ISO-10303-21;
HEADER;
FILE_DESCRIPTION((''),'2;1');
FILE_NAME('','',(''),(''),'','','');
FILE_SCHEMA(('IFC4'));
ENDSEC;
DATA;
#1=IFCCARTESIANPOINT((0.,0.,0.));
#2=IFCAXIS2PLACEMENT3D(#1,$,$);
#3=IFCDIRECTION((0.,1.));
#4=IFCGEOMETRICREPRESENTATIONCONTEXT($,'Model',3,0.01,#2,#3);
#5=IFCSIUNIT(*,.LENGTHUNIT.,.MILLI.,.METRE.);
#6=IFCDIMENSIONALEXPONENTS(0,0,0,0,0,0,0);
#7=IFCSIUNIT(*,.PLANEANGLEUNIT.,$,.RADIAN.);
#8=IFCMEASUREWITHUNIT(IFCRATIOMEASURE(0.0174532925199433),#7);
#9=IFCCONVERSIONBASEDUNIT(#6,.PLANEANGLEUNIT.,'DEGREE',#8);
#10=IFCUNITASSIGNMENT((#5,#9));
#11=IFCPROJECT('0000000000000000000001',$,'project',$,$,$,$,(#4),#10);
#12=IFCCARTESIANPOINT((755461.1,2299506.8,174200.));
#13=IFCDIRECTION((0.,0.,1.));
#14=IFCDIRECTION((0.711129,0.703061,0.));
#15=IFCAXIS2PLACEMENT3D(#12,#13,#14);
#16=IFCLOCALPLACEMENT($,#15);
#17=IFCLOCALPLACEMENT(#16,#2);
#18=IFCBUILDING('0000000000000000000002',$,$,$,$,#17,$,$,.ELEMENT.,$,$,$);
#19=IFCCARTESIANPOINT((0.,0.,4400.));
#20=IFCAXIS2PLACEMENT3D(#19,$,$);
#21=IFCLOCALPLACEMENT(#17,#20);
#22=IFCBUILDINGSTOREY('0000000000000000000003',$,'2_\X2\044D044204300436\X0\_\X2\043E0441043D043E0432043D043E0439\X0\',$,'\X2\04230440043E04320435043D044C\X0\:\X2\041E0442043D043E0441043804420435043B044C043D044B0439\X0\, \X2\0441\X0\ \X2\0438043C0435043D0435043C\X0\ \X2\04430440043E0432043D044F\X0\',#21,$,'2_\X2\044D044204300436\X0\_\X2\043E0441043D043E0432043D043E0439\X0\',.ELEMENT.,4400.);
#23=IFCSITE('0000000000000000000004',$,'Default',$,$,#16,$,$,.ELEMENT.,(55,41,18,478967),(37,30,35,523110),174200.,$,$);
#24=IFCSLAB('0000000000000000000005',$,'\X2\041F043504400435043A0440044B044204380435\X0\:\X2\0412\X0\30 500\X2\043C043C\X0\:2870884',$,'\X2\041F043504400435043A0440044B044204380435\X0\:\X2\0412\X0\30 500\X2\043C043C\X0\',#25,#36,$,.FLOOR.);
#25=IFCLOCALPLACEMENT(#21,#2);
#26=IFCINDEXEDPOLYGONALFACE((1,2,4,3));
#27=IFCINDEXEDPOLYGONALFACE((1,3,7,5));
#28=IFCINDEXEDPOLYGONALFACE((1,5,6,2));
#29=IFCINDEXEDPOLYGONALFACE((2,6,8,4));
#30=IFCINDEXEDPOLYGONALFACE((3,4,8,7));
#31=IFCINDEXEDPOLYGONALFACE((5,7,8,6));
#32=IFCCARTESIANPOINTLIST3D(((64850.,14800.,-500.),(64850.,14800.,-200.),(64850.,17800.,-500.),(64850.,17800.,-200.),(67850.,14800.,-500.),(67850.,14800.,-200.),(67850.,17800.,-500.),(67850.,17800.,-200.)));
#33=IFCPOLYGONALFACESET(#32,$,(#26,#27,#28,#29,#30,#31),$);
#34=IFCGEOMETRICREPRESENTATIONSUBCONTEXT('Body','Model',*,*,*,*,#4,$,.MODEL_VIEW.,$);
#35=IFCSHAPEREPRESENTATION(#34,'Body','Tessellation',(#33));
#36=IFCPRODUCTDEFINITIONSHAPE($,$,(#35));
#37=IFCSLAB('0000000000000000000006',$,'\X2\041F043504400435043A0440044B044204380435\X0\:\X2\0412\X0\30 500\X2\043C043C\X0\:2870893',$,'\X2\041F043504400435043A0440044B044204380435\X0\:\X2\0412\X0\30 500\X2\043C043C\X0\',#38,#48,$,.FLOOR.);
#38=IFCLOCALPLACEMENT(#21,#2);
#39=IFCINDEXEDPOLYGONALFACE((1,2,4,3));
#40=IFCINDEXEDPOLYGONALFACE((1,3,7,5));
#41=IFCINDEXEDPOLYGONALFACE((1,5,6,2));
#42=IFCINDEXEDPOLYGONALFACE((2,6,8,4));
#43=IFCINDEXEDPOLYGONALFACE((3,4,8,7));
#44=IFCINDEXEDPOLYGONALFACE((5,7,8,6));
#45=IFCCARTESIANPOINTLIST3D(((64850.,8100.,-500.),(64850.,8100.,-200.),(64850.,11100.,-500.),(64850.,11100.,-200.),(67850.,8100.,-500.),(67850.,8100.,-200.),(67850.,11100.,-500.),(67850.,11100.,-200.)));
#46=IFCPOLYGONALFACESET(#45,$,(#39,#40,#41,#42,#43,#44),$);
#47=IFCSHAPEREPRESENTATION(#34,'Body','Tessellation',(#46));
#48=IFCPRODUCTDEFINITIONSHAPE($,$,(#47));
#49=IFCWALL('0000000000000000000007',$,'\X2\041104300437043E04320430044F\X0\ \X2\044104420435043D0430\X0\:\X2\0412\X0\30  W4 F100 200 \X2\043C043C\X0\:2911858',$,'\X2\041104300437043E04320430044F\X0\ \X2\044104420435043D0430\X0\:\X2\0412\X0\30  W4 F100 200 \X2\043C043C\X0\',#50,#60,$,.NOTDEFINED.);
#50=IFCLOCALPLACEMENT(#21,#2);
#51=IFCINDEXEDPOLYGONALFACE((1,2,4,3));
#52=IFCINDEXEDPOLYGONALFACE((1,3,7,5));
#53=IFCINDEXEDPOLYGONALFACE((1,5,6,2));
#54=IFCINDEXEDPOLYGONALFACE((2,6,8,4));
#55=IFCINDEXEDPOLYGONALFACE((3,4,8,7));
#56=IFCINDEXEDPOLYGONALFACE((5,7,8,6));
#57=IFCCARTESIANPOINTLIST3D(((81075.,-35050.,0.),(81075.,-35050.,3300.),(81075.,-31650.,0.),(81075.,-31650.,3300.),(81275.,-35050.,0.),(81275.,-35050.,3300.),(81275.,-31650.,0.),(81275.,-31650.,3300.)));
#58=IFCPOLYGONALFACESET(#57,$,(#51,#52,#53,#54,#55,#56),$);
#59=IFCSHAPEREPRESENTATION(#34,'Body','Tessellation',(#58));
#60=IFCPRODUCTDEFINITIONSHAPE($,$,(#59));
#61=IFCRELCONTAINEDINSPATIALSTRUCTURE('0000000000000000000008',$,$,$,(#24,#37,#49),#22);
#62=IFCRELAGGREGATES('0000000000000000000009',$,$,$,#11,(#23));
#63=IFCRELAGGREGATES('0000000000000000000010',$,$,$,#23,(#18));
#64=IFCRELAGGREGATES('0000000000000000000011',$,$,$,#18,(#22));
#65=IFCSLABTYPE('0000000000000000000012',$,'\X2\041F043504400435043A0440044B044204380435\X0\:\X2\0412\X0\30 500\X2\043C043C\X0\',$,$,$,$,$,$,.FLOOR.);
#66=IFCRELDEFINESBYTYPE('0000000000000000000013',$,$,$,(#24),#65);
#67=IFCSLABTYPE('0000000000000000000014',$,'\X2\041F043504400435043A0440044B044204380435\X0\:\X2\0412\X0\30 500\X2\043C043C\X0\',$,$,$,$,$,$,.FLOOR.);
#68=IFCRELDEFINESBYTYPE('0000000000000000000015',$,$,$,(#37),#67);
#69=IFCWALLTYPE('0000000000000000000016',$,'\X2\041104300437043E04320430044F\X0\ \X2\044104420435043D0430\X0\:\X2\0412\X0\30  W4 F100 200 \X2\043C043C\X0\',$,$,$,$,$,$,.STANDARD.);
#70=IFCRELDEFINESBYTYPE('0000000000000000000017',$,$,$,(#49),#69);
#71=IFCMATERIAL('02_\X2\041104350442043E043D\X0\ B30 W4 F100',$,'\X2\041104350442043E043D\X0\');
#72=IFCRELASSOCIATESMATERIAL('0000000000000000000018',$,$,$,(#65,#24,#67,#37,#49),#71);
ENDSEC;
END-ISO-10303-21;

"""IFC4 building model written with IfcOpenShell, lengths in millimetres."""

from ifc_helpers import new_model, entity, si_unit, converted_unit, direction, frame, origin, place, context, subcontext, project, spatial, indexed_curve, outline, extrude, material, type_object, element, save


model = new_model("IFC4")

# Units and contexts
model_context = context("Model", 3, precision=0.01, world=origin(), true_north=direction((0.0, 1.0)))
body_context = subcontext(model_context, "Body", "Model", "MODEL_VIEW")
ifc_project = project(units=[si_unit("LENGTHUNIT", "METRE", prefix="MILLI"), converted_unit("PLANEANGLEUNIT", "DEGREE", entity("IfcRatioMeasure", 0.0174532925199433), si_unit("PLANEANGLEUNIT", "RADIAN"), dimensions=[0, 0, 0, 0, 0, 0, 0])], contexts=[model_context])

# Site, building, storey
site_placement = place(None, frame((755461.1, 2299506.8, 174200.0), z_axis=(0.0, 0.0, 1.0), x_axis=(0.711129, 0.703061, 0.0)))
site = spatial("IfcSite", under=ifc_project, at=site_placement, Name="Default", CompositionType="ELEMENT", RefLatitude=(55, 41, 18, 478967), RefLongitude=(37, 30, 35, 523110), RefElevation=174200.0)
building_placement = place(site_placement, origin())
building = spatial("IfcBuilding", under=site, at=building_placement, CompositionType="ELEMENT")
storey_placement = place(building_placement, frame((0.0, 0.0, 4400.0)))
storey = spatial("IfcBuildingStorey", under=building, at=storey_placement, Name="2_этаж_основной", ObjectType="Уровень:Относительный, с именем уровня", LongName="2_этаж_основной", CompositionType="ELEMENT", Elevation=4400.0)

# Shared definitions
ifc_material_1 = material(Name="02_Бетон B30 W4 F100", Category="Бетон")

# Slabs
slab_type_1 = type_object("IfcSlabType", Name="Перекрытие:В30 500мм", PredefinedType="FLOOR", material=ifc_material_1)
slab_1_placement = place(storey_placement, origin())
element("IfcSlab", 1, at=slab_1_placement, inside=storey, type_object=slab_type_1, material=ifc_material_1, Name="Перекрытие:В30 500мм:2870884", ObjectType="Перекрытие:В30 500мм", PredefinedType="FLOOR", context=body_context, shape_type="SweptSolid", body=[
    extrude(outline(indexed_curve([(-1500.0, -1500.0), (1500.0, -1500.0), (1500.0, 1500.0), (-1500.0, 1500.0), (-1500.0, -1500.0)], self_intersect=False)), frame((66350.0, 16300.0, -500.0), z_axis=(0.0, 0.0, 1.0), x_axis=(0.0, -1.0, 0.0)), (0.0, 0.0, 1.0), 300.0),
])
slab_type_2 = type_object("IfcSlabType", Name="Перекрытие:В30 500мм", PredefinedType="FLOOR", material=ifc_material_1)
slab_2_placement = place(storey_placement, origin())
element("IfcSlab", 2, at=slab_2_placement, inside=storey, type_object=slab_type_2, material=ifc_material_1, Name="Перекрытие:В30 500мм:2870893", ObjectType="Перекрытие:В30 500мм", PredefinedType="FLOOR", context=body_context, shape_type="SweptSolid", body=[
    extrude(outline(indexed_curve([(-1500.0, -1500.0), (1500.0, -1500.0), (1500.0, 1500.0), (-1500.0, 1500.0), (-1500.0, -1500.0)], self_intersect=False)), frame((66350.0, 9600.0, -500.0), z_axis=(0.0, 0.0, 1.0), x_axis=(0.0, -1.0, 0.0)), (0.0, 0.0, 1.0), 300.0),
])

# Wall
wall_type = type_object("IfcWallType", Name="Базовая стена:В30  W4 F100 200 мм", PredefinedType="STANDARD")
wall_placement = place(storey_placement, frame((81175.0, -31650.0, 0.0), z_axis=(0.0, 0.0, 1.0), x_axis=(0.0, -1.0, 0.0)))
element("IfcWall", 3, at=wall_placement, inside=storey, type_object=wall_type, material=ifc_material_1, Name="Базовая стена:В30  W4 F100 200 мм:2911858", ObjectType="Базовая стена:В30  W4 F100 200 мм", PredefinedType="NOTDEFINED", context=body_context, shape_type="SweptSolid", body=[
    extrude(outline(indexed_curve([(3400.0, 100.0), (0.0, 100.0), (0.0, -100.0), (3400.0, -100.0), (3400.0, 100.0)], self_intersect=False)), origin(), (0.0, 0.0, 1.0), 3300.0),
])

save(model, "model.ifc")
